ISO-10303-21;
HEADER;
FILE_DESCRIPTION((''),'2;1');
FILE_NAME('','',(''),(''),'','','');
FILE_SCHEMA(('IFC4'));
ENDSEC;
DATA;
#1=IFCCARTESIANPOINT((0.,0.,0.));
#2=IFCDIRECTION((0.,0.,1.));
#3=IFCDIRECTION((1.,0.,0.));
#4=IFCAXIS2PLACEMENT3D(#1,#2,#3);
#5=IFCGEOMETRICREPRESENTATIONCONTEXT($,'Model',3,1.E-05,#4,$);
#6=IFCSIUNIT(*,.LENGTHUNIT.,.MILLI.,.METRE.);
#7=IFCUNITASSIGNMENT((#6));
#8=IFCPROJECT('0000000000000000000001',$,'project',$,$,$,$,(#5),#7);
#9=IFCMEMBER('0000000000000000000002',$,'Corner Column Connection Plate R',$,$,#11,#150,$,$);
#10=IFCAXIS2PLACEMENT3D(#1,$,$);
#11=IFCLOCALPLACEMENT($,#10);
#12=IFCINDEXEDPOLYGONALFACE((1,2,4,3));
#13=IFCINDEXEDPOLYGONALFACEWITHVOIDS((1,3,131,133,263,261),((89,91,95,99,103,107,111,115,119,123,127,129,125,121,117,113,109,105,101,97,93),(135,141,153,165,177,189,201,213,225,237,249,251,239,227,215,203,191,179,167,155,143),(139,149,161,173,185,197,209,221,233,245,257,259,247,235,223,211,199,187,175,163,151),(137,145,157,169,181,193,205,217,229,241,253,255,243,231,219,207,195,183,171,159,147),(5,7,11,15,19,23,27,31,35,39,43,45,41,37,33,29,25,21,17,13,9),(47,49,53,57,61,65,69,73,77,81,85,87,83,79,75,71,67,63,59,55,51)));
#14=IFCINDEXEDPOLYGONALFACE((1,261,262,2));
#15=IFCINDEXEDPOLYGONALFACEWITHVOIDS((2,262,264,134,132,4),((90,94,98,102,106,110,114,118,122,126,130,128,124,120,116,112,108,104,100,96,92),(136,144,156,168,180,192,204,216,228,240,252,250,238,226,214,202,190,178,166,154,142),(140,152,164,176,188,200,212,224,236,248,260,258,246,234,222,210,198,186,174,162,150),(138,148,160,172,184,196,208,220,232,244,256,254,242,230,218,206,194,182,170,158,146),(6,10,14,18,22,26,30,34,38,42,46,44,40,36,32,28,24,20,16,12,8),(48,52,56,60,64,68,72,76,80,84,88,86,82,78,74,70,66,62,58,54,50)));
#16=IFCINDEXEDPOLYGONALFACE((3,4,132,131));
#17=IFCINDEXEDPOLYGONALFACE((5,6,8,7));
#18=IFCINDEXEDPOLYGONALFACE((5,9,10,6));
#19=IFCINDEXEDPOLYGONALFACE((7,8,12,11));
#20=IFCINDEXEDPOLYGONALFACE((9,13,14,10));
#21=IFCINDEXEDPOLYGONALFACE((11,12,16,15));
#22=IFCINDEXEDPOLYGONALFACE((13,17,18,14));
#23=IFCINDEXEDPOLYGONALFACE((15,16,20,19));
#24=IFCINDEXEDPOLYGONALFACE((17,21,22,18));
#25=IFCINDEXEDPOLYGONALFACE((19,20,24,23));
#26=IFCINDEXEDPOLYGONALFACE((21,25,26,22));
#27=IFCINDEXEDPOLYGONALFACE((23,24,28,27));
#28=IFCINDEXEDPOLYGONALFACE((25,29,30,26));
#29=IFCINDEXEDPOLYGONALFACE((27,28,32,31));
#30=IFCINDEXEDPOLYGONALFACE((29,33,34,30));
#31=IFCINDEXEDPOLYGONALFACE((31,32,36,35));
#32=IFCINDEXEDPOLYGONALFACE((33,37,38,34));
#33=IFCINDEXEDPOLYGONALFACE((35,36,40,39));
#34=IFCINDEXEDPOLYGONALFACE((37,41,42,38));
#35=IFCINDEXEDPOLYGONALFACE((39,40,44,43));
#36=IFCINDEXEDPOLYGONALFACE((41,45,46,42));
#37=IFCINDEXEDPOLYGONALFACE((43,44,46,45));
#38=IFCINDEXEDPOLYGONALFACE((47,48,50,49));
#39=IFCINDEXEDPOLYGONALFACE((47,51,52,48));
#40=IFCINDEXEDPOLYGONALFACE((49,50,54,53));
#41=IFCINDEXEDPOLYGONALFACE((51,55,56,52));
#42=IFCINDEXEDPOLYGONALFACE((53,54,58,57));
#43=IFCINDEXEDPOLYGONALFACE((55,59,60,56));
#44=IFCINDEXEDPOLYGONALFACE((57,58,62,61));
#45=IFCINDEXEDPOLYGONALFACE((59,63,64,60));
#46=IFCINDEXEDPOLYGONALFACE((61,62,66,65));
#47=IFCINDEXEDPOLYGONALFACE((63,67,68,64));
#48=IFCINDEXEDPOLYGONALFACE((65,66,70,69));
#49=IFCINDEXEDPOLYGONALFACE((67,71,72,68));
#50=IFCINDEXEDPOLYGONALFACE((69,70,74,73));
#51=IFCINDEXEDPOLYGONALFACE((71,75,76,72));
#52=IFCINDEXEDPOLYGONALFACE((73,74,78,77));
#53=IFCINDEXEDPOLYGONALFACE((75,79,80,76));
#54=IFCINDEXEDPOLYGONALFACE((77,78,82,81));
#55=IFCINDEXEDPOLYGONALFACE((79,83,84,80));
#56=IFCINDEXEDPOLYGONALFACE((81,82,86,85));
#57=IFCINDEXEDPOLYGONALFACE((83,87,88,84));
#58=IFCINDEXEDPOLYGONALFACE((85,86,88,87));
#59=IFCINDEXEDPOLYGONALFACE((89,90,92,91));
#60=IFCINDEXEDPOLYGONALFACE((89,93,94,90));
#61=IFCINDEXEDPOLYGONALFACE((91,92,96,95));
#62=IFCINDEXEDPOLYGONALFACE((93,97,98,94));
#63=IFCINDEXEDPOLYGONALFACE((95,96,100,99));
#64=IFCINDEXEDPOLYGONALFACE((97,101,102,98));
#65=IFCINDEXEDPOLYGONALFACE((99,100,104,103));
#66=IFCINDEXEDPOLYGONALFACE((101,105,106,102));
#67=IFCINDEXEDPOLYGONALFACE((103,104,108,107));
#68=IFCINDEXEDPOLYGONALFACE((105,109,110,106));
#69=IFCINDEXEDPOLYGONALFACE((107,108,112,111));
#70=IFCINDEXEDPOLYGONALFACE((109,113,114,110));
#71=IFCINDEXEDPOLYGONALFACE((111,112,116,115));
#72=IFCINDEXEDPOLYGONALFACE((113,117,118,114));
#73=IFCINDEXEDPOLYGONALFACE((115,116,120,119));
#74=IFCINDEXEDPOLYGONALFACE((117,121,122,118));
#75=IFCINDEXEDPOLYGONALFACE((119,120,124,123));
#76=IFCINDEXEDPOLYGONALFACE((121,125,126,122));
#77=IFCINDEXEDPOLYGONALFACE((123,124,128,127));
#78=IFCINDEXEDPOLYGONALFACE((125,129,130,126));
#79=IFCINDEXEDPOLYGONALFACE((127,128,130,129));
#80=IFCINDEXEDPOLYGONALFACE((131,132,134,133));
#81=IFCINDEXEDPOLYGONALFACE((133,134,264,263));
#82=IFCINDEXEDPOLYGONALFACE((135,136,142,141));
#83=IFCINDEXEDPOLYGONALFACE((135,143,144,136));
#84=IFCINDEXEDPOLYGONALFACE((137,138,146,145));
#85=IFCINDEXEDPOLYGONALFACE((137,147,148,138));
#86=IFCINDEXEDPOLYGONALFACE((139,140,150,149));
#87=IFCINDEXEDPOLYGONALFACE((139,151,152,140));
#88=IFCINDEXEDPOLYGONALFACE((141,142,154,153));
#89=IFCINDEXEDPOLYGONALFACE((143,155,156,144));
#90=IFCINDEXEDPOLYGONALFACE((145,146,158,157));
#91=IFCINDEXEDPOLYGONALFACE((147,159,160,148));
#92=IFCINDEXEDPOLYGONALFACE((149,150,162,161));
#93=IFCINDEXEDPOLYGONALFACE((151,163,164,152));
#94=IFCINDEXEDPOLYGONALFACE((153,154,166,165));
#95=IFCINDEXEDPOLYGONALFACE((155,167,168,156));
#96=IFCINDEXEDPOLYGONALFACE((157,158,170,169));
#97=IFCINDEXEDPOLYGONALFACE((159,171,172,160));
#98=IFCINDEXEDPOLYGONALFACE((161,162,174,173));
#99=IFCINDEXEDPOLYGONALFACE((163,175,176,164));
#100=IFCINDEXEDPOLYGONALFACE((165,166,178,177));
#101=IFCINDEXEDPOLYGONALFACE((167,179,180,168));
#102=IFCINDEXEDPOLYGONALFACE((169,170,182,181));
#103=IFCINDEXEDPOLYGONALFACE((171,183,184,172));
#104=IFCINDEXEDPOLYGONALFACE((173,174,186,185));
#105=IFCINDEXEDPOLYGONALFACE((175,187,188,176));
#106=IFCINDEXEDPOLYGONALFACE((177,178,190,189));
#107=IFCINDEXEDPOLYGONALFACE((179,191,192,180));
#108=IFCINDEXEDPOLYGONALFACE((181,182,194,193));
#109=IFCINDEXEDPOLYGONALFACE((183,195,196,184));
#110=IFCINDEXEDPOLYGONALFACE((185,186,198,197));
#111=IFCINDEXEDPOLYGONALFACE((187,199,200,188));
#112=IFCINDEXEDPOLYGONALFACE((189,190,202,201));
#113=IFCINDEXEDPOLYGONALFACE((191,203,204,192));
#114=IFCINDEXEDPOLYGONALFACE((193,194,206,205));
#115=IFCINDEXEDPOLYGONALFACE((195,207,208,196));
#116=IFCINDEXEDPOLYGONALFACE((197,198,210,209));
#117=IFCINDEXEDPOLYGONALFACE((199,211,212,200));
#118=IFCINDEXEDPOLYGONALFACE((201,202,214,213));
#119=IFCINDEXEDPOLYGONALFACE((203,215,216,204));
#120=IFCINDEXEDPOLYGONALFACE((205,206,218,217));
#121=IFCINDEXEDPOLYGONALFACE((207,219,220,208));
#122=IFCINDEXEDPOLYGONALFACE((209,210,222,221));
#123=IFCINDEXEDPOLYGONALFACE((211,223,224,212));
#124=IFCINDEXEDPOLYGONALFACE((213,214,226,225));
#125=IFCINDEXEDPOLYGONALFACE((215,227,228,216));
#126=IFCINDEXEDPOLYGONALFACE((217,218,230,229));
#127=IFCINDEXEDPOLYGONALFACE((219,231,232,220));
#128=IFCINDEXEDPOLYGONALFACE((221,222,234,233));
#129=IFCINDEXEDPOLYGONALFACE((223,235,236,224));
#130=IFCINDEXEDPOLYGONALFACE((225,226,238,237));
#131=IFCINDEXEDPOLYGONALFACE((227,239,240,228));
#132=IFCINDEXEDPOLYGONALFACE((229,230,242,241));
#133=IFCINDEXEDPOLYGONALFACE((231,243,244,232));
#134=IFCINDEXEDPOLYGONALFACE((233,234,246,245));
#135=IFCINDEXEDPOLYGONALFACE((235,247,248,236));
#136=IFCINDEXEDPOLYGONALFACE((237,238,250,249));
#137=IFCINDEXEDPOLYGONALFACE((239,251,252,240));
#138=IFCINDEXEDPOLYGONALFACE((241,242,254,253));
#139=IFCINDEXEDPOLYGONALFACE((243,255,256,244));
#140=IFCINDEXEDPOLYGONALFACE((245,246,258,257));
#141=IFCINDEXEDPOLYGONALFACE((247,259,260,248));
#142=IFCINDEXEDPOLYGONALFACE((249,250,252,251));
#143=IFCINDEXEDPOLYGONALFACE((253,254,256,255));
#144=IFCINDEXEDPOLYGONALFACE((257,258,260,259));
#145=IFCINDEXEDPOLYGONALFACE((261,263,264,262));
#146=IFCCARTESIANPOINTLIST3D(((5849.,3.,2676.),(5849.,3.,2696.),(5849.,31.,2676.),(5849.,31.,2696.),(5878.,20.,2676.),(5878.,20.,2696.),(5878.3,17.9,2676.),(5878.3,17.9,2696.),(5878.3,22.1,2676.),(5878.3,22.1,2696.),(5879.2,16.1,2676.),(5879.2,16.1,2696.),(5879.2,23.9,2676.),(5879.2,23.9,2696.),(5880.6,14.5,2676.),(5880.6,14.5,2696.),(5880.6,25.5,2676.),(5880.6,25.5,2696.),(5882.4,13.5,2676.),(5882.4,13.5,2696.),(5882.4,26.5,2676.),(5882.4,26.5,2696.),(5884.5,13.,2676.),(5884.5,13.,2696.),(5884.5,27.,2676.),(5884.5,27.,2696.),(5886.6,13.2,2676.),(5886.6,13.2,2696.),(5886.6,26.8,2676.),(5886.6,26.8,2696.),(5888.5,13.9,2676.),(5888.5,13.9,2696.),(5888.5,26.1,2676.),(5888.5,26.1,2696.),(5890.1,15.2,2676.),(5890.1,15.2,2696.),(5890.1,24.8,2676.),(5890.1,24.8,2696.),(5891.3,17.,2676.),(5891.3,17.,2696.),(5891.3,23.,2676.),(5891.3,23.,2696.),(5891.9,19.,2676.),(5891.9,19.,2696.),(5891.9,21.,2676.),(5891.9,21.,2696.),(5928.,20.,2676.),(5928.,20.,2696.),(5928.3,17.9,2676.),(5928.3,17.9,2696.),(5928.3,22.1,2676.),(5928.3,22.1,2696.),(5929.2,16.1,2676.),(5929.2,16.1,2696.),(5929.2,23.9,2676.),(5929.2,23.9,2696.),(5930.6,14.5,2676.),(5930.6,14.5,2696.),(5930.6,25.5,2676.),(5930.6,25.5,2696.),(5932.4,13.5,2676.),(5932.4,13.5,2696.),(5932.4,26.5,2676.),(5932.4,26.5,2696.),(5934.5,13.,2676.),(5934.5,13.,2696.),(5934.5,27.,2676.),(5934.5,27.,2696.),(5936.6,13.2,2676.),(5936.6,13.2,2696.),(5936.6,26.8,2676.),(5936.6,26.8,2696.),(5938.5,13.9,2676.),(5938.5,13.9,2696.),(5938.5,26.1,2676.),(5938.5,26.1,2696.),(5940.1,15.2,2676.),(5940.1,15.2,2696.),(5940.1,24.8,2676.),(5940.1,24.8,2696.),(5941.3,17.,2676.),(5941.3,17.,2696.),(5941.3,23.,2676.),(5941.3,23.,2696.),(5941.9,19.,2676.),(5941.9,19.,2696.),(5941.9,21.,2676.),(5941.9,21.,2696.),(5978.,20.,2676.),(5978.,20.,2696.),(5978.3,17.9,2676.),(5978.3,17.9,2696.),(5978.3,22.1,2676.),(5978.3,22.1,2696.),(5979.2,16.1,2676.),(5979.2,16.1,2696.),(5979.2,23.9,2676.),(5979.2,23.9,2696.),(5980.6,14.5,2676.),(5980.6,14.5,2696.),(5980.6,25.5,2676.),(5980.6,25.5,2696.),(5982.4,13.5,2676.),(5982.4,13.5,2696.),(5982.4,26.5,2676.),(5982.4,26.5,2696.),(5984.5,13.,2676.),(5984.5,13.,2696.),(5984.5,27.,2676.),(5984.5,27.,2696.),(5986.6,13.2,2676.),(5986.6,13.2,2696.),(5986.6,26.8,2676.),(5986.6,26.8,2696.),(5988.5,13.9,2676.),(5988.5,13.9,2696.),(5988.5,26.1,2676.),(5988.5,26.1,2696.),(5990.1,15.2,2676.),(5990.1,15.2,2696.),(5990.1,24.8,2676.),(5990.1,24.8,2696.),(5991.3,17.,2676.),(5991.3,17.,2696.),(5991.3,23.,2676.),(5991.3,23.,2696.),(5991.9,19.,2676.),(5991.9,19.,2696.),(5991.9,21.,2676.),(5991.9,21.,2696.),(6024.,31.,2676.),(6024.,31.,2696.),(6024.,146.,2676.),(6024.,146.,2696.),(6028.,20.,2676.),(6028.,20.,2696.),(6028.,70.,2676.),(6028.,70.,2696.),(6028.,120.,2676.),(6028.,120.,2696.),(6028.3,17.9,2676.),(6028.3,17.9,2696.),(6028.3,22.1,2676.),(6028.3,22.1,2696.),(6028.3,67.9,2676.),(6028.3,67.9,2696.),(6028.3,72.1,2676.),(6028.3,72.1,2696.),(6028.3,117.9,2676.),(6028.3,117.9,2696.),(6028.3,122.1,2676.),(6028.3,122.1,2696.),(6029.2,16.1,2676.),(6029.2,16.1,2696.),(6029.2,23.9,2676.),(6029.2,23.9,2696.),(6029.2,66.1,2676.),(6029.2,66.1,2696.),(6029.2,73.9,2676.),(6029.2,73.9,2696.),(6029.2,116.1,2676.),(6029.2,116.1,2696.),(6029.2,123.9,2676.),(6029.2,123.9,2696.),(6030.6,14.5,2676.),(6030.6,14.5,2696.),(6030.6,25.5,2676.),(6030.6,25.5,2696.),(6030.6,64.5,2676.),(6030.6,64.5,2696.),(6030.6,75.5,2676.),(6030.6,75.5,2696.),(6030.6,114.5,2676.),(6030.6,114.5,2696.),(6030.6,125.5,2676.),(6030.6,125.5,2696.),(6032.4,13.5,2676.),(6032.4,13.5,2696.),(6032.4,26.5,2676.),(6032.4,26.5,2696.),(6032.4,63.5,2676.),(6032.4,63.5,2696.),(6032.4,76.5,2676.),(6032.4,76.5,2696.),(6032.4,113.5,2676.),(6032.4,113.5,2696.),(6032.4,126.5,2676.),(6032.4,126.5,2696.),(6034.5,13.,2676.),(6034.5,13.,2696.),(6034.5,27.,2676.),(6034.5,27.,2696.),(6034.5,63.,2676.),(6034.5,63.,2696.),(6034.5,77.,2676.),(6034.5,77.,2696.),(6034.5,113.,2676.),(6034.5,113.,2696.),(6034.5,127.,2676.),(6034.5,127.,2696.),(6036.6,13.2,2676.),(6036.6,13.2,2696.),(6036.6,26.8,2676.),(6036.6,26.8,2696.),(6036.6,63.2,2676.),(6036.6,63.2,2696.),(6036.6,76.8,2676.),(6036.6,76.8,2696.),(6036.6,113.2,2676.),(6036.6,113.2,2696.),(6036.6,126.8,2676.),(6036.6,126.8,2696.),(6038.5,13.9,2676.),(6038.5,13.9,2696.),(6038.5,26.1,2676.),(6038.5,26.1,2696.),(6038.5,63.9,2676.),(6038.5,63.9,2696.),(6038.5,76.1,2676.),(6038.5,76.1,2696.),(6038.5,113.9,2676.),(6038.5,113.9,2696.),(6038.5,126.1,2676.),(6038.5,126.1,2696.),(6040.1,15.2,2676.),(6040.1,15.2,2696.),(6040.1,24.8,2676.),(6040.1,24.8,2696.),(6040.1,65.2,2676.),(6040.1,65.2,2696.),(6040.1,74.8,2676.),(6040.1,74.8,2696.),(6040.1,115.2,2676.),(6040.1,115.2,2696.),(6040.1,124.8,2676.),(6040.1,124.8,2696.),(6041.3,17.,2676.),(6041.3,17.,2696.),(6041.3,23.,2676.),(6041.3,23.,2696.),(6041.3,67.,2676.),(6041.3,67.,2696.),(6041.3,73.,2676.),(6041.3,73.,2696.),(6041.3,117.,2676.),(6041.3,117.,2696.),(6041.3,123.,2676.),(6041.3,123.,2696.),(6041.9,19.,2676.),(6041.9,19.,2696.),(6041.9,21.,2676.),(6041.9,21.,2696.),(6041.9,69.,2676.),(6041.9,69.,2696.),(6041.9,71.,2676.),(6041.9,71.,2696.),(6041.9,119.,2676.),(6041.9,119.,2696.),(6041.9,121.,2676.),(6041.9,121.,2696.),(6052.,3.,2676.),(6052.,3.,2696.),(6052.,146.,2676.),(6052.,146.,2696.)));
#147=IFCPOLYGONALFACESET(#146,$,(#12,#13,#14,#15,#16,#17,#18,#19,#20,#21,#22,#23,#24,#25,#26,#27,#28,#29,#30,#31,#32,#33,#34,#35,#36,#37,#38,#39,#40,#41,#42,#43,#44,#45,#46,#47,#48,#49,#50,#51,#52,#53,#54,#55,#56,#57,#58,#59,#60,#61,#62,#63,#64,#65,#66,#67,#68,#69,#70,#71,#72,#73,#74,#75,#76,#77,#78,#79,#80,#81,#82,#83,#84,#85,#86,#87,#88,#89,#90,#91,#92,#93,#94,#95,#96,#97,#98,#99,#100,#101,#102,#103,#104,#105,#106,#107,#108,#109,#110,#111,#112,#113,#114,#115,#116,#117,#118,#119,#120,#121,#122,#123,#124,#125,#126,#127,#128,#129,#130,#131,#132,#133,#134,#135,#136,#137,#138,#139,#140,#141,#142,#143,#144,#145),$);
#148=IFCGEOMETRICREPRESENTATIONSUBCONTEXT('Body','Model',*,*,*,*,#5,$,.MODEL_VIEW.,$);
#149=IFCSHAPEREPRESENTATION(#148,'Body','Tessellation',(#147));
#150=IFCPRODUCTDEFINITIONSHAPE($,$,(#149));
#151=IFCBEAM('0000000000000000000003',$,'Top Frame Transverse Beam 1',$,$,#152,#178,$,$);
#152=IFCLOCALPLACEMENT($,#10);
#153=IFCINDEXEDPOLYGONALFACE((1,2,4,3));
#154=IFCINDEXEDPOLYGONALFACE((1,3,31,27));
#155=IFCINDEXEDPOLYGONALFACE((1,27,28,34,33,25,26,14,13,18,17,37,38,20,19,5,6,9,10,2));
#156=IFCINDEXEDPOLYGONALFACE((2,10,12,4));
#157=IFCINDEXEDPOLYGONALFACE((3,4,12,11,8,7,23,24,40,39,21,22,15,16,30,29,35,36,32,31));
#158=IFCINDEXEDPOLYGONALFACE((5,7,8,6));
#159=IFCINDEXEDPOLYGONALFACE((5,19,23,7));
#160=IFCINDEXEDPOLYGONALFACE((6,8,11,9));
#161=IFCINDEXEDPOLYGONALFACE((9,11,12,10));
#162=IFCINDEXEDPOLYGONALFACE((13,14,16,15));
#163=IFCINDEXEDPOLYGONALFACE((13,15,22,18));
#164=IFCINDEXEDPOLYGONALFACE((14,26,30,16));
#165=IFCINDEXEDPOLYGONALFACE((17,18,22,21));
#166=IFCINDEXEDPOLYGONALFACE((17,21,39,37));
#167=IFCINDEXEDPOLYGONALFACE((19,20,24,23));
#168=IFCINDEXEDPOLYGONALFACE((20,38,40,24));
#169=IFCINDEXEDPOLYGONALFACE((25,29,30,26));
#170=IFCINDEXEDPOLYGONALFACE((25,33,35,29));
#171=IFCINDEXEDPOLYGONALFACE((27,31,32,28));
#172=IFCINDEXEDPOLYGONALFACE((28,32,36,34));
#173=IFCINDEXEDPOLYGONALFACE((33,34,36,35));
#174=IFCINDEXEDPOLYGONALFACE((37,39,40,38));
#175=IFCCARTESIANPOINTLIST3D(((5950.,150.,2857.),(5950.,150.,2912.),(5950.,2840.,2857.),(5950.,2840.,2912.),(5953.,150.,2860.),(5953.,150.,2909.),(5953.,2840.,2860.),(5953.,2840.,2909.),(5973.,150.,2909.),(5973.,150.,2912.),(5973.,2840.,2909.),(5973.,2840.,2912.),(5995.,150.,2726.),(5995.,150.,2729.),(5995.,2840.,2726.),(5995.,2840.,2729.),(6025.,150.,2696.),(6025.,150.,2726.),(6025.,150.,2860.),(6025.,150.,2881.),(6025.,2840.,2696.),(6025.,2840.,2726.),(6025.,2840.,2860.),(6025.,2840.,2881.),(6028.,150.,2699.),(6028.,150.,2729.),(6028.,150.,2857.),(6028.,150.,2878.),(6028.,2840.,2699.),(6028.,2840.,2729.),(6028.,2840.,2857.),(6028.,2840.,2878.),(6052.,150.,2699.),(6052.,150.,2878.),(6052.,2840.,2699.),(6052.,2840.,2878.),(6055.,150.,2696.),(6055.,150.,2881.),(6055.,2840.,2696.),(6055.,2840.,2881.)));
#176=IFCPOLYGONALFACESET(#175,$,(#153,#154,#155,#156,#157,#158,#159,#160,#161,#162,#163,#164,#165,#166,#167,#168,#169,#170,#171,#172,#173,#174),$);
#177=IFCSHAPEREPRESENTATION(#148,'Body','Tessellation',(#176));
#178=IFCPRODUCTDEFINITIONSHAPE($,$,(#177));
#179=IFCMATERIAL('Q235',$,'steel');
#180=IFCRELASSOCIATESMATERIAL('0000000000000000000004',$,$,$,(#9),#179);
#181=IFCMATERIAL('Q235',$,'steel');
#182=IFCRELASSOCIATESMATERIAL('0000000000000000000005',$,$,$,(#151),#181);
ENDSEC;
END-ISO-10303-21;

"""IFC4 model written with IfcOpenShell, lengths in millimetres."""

from ifc_helpers import new_model, si_unit, frame, origin_with_axes, origin_2d, place, context, subcontext, project, line, indexed_curve, circle_curve, outline, extrude, material, element, save


model = new_model("IFC4")

# Units and contexts
model_context = context("Model", 3, precision=1e-05, world=origin_with_axes())
body_context = subcontext(model_context, "Body", "Model", "MODEL_VIEW")
ifc_project = project(units=[si_unit("LENGTHUNIT", "METRE", prefix="MILLI")], contexts=[model_context])

# Member, openings
ifc_material_1 = material(Name="Q235", Category="steel")
member_1_placement = place(None, frame((6052.0, 3.0, 2676.0), z_axis=(0.0, 0.0, 1.0), x_axis=(-1.0, 0.0, 0.0)))
member_1 = element("IfcMember", 1, at=member_1_placement, material=ifc_material_1, Name="Corner Column Connection Plate R", context=body_context, shape_type="SweptSolid", body=[
    extrude(outline(indexed_curve([(0.0, 0.0), (203.0, 0.0), (203.0, -28.0), (28.0, -28.0), (28.0, -143.0), (0.0, -143.0), (0.0, 0.0)], segments=[line(1, 2, 3, 4, 5, 6, 7, 1)])), origin_with_axes(), (0.0, 0.0, 1.0), 20.0),
])
opening_1_placement = place(member_1_placement, frame((17.0, -17.0, 0.0), z_axis=(0.0, 0.0, 1.0), x_axis=(1.0, 0.0, 0.0)))
element("IfcOpeningElement", 2, at=opening_1_placement, cuts=member_1, context=body_context, shape_type="SweptSolid", body=[
    extrude(outline(circle_curve(origin_2d(), 7.0)), origin_with_axes(), (0.0, 0.0, 1.0), 20.0),
])
opening_2_placement = place(member_1_placement, frame((67.0, -17.0, 0.0), z_axis=(0.0, 0.0, 1.0), x_axis=(1.0, 0.0, 0.0)))
element("IfcOpeningElement", 3, at=opening_2_placement, cuts=member_1, context=body_context, shape_type="SweptSolid", body=[
    extrude(outline(circle_curve(origin_2d(), 7.0)), origin_with_axes(), (0.0, 0.0, 1.0), 20.0),
])
opening_3_placement = place(member_1_placement, frame((117.0, -17.0, 0.0), z_axis=(0.0, 0.0, 1.0), x_axis=(1.0, 0.0, 0.0)))
element("IfcOpeningElement", 4, at=opening_3_placement, cuts=member_1, context=body_context, shape_type="SweptSolid", body=[
    extrude(outline(circle_curve(origin_2d(), 7.0)), origin_with_axes(), (0.0, 0.0, 1.0), 20.0),
])
opening_4_placement = place(member_1_placement, frame((167.0, -17.0, 0.0), z_axis=(0.0, 0.0, 1.0), x_axis=(1.0, 0.0, 0.0)))
element("IfcOpeningElement", 5, at=opening_4_placement, cuts=member_1, context=body_context, shape_type="SweptSolid", body=[
    extrude(outline(circle_curve(origin_2d(), 7.0)), origin_with_axes(), (0.0, 0.0, 1.0), 20.0),
])
opening_5_placement = place(member_1_placement, frame((17.0, -67.0, 0.0), z_axis=(0.0, 0.0, 1.0), x_axis=(1.0, 0.0, 0.0)))
element("IfcOpeningElement", 6, at=opening_5_placement, cuts=member_1, context=body_context, shape_type="SweptSolid", body=[
    extrude(outline(circle_curve(origin_2d(), 7.0)), origin_with_axes(), (0.0, 0.0, 1.0), 20.0),
])
opening_6_placement = place(member_1_placement, frame((17.0, -117.0, 0.0), z_axis=(0.0, 0.0, 1.0), x_axis=(1.0, 0.0, 0.0)))
element("IfcOpeningElement", 7, at=opening_6_placement, cuts=member_1, context=body_context, shape_type="SweptSolid", body=[
    extrude(outline(circle_curve(origin_2d(), 7.0)), origin_with_axes(), (0.0, 0.0, 1.0), 20.0),
])

# Beam
ifc_material_2 = material(Name="Q235", Category="steel")
beam_1_placement = place(None, frame((6055.0, 150.0, 2696.0), z_axis=(0.0, 1.0, 0.0), x_axis=(-1.0, 0.0, 0.0)))
element("IfcBeam", 8, at=beam_1_placement, material=ifc_material_2, Name="Top Frame Transverse Beam 1", context=body_context, shape_type="SweptSolid", body=[
    extrude(outline(indexed_curve([(60.0, 30.0), (30.0, 30.0), (30.0, 0.0), (0.0, 0.0), (0.0, 185.0), (30.0, 185.0), (30.0, 164.0), (102.0, 164.0), (102.0, 213.0), (82.0, 213.0), (82.0, 216.0), (105.0, 216.0), (105.0, 161.0), (27.0, 161.0), (27.0, 182.0), (3.0, 182.0), (3.0, 3.0), (27.0, 3.0), (27.0, 33.0), (60.0, 33.0), (60.0, 30.0)], segments=[line(1, 2, 3, 4, 5, 6, 7, 8, 9, 10, 11, 12, 13, 14, 15, 16, 17, 18, 19, 20, 21, 1)])), origin_with_axes(), (0.0, 0.0, 1.0), 2690.0),
])

save(model, "model.ifc")
